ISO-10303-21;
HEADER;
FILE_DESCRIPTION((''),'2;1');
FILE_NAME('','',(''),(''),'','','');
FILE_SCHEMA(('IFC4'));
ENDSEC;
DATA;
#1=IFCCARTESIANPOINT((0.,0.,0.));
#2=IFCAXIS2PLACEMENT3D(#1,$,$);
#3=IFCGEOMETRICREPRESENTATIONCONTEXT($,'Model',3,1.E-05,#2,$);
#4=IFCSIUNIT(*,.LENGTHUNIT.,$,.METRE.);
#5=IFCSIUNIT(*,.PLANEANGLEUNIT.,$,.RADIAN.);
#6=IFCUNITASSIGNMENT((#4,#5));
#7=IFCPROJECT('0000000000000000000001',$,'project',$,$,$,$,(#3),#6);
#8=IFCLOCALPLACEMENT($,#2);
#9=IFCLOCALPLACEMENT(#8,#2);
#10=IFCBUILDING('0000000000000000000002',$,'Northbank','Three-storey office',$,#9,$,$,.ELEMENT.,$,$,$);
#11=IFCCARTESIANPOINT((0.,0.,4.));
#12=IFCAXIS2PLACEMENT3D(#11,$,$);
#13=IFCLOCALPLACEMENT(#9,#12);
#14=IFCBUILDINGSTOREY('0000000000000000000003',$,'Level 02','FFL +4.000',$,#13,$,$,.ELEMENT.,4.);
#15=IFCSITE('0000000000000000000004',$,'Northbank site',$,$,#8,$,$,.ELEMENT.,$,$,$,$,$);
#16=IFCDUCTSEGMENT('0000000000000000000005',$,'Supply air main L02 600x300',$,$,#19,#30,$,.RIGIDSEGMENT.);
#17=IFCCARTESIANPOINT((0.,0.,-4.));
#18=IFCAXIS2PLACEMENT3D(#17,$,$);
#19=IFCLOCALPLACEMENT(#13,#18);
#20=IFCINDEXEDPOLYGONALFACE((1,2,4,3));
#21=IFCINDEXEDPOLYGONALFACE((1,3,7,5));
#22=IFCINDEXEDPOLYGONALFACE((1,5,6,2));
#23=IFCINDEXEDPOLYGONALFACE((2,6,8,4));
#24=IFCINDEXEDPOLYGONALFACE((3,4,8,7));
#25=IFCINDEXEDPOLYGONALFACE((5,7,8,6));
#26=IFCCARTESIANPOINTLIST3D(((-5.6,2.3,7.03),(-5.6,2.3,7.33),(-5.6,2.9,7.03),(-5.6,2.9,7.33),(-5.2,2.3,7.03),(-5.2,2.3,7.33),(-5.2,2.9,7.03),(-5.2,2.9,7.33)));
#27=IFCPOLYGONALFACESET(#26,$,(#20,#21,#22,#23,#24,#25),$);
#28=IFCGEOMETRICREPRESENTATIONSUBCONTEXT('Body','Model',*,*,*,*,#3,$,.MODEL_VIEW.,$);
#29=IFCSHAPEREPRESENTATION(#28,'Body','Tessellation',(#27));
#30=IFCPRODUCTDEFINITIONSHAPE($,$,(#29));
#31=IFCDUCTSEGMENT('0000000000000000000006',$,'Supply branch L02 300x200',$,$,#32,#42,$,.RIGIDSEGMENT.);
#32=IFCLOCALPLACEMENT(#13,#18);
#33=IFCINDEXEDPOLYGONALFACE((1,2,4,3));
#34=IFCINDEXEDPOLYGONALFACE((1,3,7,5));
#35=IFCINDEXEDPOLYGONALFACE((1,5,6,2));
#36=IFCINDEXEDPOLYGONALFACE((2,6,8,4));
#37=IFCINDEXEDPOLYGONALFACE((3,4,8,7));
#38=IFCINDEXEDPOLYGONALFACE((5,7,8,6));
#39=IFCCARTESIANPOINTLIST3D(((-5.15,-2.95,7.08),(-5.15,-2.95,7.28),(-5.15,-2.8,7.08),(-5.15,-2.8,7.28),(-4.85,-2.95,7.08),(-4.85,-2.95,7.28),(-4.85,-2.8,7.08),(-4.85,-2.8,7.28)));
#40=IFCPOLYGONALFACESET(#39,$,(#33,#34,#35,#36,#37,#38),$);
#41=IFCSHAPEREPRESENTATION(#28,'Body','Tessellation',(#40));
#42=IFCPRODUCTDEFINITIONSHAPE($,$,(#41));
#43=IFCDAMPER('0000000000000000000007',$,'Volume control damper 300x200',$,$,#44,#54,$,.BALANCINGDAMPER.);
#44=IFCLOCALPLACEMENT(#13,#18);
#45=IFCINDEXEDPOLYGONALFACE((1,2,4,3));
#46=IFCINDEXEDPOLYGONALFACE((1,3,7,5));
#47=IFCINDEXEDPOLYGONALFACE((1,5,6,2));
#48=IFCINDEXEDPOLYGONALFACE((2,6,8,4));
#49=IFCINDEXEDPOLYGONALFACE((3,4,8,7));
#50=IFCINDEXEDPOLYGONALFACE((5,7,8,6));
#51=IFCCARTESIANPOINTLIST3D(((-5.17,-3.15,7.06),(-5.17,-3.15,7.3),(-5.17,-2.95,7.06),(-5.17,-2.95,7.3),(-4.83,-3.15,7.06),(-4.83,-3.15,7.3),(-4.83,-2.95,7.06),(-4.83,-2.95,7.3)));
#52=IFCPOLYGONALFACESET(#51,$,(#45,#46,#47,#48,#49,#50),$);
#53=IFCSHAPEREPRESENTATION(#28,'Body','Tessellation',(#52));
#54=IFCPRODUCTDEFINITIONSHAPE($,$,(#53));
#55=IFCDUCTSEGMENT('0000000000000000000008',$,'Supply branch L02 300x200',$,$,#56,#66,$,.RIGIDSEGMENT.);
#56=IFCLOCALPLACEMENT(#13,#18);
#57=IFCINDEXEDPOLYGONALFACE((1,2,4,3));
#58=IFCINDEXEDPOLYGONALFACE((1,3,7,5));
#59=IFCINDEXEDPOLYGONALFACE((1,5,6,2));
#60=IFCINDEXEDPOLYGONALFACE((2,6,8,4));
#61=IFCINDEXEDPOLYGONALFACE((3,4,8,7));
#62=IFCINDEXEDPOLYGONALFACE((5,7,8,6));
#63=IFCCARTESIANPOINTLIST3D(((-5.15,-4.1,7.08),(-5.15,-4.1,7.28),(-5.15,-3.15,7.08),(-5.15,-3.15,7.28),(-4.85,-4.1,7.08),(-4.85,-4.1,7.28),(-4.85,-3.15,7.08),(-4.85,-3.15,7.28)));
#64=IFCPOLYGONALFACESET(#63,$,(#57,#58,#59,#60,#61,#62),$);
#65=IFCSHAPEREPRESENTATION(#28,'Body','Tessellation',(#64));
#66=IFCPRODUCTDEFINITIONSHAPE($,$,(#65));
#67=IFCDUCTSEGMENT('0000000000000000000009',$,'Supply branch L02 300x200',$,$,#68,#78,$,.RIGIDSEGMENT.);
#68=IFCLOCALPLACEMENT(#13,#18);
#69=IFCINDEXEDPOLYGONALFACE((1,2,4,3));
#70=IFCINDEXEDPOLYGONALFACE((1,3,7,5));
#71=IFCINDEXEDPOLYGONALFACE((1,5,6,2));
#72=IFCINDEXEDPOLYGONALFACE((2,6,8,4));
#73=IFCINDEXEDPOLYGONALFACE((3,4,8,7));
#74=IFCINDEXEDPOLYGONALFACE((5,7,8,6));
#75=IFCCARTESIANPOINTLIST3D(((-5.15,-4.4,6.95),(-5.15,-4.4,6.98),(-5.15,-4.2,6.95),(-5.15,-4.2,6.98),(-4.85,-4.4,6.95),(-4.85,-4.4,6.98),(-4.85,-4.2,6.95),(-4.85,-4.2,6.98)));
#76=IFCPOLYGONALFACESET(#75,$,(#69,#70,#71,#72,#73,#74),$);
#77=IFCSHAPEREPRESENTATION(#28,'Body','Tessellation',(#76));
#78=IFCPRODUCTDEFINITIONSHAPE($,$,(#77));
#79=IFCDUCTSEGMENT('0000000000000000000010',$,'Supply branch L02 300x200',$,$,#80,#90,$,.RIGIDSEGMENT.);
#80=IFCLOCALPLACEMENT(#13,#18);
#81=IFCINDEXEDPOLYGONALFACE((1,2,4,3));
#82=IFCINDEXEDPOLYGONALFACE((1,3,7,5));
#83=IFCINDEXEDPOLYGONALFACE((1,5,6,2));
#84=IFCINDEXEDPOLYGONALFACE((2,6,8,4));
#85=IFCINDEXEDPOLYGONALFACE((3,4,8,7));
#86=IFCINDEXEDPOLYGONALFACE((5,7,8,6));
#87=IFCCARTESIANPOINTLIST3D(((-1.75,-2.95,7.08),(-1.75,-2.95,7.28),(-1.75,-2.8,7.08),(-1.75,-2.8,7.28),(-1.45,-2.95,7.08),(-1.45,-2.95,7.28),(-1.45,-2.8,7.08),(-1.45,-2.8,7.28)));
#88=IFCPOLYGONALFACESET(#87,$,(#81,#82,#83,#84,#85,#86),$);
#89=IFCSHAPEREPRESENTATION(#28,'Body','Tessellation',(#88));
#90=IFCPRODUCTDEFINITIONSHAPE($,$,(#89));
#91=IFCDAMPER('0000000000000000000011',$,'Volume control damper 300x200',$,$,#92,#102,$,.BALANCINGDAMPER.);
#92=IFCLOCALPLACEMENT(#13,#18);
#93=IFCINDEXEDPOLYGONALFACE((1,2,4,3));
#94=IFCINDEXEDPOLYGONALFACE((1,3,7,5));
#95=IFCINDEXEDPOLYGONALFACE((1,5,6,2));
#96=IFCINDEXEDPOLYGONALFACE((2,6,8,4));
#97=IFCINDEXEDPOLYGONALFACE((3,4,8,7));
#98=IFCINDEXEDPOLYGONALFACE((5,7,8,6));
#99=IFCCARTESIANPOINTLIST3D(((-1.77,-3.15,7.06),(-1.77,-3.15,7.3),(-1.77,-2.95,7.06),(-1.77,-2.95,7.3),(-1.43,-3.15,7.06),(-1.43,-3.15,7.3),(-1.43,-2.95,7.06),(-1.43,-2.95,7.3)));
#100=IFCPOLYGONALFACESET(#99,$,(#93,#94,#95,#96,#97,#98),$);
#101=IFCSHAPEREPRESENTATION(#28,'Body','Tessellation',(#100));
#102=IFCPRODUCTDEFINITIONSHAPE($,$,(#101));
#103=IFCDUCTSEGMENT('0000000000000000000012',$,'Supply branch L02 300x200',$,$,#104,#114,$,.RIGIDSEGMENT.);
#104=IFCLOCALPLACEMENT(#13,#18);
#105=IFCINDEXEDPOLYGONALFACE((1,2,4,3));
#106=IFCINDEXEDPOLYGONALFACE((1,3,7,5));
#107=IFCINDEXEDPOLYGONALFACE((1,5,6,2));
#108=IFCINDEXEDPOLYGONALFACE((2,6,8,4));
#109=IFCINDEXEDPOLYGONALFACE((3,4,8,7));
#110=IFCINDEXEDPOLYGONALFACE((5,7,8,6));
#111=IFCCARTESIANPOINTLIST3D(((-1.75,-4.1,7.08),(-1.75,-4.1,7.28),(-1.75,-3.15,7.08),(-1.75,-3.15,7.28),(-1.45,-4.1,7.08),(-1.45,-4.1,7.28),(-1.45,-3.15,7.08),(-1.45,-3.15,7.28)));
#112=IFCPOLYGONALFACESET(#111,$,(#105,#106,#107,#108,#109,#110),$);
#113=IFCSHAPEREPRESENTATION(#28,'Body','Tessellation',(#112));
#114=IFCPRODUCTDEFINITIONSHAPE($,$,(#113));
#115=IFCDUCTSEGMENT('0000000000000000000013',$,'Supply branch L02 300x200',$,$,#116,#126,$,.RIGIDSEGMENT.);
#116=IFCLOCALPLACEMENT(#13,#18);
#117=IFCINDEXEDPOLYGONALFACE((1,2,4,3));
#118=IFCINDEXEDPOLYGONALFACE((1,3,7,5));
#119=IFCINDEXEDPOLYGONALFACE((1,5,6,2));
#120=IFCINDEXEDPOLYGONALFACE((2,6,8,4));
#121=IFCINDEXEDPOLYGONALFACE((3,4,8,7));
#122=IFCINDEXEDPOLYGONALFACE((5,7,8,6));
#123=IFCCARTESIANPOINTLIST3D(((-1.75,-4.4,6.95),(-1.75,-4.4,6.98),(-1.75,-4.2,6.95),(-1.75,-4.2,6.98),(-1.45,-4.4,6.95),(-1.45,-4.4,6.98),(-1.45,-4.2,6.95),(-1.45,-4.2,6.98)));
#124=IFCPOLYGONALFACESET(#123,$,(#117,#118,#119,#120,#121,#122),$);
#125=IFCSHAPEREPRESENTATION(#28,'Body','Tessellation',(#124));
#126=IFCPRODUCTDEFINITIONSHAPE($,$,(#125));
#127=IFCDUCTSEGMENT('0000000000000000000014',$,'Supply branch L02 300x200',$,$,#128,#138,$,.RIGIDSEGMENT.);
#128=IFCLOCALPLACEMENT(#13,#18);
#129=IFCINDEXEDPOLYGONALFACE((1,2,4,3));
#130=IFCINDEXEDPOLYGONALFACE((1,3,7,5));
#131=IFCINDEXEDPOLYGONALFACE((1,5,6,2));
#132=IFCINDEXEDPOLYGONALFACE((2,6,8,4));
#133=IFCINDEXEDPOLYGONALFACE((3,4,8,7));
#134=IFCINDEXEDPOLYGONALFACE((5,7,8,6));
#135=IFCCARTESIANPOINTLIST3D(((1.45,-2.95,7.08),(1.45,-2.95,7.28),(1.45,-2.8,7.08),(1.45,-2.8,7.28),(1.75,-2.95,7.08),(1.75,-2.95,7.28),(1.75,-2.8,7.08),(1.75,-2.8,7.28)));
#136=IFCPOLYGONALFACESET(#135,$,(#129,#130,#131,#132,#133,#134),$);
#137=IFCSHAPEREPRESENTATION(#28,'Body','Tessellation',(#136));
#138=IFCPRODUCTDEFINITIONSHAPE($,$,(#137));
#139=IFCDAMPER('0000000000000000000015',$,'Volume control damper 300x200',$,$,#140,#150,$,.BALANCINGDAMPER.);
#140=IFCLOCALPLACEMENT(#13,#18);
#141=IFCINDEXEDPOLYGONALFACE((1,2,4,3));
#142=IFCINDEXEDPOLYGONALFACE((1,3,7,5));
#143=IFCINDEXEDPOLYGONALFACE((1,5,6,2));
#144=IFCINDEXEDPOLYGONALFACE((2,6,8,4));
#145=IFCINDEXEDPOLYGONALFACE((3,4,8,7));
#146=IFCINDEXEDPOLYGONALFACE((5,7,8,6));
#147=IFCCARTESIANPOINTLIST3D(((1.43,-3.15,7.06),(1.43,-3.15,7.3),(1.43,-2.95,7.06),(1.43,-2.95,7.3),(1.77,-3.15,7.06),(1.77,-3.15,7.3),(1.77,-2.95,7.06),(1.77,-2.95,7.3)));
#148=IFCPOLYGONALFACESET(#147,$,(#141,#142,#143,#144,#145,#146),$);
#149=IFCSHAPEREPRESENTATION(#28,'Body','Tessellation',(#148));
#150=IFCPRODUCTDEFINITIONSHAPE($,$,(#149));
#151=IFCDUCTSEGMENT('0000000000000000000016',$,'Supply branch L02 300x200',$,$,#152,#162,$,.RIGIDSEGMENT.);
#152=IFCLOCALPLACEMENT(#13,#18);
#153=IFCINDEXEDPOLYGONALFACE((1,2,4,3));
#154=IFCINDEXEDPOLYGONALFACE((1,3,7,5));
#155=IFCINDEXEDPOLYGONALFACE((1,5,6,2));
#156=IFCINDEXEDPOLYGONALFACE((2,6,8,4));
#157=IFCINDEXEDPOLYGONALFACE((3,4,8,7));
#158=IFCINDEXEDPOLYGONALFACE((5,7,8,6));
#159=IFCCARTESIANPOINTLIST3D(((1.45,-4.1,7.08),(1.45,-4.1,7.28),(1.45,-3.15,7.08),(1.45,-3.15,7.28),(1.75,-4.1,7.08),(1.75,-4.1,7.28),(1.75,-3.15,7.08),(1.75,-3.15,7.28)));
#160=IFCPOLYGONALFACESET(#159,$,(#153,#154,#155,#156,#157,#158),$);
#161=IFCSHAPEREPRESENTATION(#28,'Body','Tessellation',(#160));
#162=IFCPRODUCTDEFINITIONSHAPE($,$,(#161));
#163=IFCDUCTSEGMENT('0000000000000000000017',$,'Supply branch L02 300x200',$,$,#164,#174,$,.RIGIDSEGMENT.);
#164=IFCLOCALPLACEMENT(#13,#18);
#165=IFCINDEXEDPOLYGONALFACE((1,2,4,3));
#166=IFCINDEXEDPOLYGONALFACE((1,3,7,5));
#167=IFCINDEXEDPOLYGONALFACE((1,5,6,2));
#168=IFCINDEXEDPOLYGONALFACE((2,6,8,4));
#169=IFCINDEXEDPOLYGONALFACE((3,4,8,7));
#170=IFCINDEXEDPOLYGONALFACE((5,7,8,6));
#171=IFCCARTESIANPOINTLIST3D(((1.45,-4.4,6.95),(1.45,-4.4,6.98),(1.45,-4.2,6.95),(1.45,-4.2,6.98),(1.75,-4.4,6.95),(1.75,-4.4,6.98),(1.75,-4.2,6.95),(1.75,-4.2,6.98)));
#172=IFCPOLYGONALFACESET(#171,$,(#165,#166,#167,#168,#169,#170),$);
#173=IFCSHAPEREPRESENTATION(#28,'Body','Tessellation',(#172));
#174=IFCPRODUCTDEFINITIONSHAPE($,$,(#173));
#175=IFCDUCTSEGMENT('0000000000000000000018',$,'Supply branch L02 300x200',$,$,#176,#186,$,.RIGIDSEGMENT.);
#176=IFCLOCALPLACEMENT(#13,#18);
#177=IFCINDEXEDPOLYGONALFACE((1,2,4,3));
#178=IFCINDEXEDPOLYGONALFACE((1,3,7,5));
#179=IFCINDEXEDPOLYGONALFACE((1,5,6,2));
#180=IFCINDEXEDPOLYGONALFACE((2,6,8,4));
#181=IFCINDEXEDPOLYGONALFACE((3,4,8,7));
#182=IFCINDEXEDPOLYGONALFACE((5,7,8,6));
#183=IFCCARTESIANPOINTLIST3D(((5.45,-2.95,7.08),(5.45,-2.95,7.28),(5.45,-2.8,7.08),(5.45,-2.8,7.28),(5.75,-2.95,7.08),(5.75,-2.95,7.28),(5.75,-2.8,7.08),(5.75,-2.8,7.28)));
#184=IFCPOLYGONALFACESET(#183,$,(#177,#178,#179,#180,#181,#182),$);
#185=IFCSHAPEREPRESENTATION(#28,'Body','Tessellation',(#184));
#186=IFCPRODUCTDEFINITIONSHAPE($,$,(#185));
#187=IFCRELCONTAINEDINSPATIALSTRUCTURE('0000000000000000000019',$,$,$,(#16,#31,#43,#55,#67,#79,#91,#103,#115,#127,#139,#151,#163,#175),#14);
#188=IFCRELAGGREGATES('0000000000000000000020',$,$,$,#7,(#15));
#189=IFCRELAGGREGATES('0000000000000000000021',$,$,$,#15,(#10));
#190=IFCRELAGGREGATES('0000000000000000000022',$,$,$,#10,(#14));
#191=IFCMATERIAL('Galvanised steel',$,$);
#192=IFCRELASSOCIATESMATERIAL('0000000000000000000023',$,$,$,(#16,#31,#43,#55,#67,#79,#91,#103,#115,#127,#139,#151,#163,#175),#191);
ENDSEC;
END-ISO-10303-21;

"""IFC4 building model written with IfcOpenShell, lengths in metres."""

from ifc_helpers import new_model, si_unit, frame, origin, place, context, subcontext, project, spatial, rectangle, extrude, material, element, save


model = new_model("IFC4")

# Units and contexts
model_context = context("Model", 3, precision=1e-05, world=origin())
body_context = subcontext(model_context, "Body", "Model", "MODEL_VIEW")
ifc_project = project(units=[si_unit("LENGTHUNIT", "METRE"), si_unit("PLANEANGLEUNIT", "RADIAN")], contexts=[model_context])

# Site, building, storey
site_placement = place(None, origin())
site = spatial("IfcSite", under=ifc_project, at=site_placement, Name="Northbank site", CompositionType="ELEMENT")
building_placement = place(site_placement, origin())
building = spatial("IfcBuilding", under=site, at=building_placement, Name="Northbank", Description="Three-storey office", CompositionType="ELEMENT")
storey_placement = place(building_placement, frame((0.0, 0.0, 4.0)))
storey = spatial("IfcBuildingStorey", under=building, at=storey_placement, Name="Level 02", Description="FFL +4.000", CompositionType="ELEMENT", Elevation=4.0)

# Duct segment
ifc_material_1 = material(Name="Galvanised steel")
duct_segment_1_placement = place(storey_placement, frame((0.0, 0.0, -4.0)))
element("IfcDuctSegment", 1, at=duct_segment_1_placement, inside=storey, material=ifc_material_1, Name="Supply air main L02 600x300", PredefinedType="RIGIDSEGMENT", context=body_context, shape_type="SweptSolid", body=[
    extrude(rectangle(XDim=0.6, YDim=0.3), frame((-5.2, 2.6, 7.18), z_axis=(-1.0, 0.0, 0.0), x_axis=(0.0, -1.0, 0.0)), (0.0, 0.0, 1.0), 0.4),
])

# Duct segment
duct_segment_2_placement = place(storey_placement, frame((0.0, 0.0, -4.0)))
element("IfcDuctSegment", 2, at=duct_segment_2_placement, inside=storey, material=ifc_material_1, Name="Supply branch L02 300x200", PredefinedType="RIGIDSEGMENT", context=body_context, shape_type="SweptSolid", body=[
    extrude(rectangle(XDim=0.3, YDim=0.2), frame((-5.0, -2.8, 7.18), z_axis=(0.0, -1.0, 0.0), x_axis=(1.0, 0.0, 0.0)), (0.0, 0.0, 1.0), 0.15),
])

# Damper
damper_1_placement = place(storey_placement, frame((0.0, 0.0, -4.0)))
element("IfcDamper", 3, at=damper_1_placement, inside=storey, material=ifc_material_1, Name="Volume control damper 300x200", PredefinedType="BALANCINGDAMPER", context=body_context, shape_type="SweptSolid", body=[
    extrude(rectangle(XDim=0.34, YDim=0.24), frame((-5.0, -2.95, 7.18), z_axis=(0.0, -1.0, 0.0), x_axis=(1.0, 0.0, 0.0)), (0.0, 0.0, 1.0), 0.2),
])

# Duct segments
duct_segment_3_placement = place(storey_placement, frame((0.0, 0.0, -4.0)))
element("IfcDuctSegment", 4, at=duct_segment_3_placement, inside=storey, material=ifc_material_1, Name="Supply branch L02 300x200", PredefinedType="RIGIDSEGMENT", context=body_context, shape_type="SweptSolid", body=[
    extrude(rectangle(XDim=0.3, YDim=0.2), frame((-5.0, -3.15, 7.18), z_axis=(0.0, -1.0, 0.0), x_axis=(1.0, 0.0, 0.0)), (0.0, 0.0, 1.0), 0.95),
])
duct_segment_4_placement = place(storey_placement, frame((0.0, 0.0, -4.0)))
element("IfcDuctSegment", 5, at=duct_segment_4_placement, inside=storey, material=ifc_material_1, Name="Supply branch L02 300x200", PredefinedType="RIGIDSEGMENT", context=body_context, shape_type="SweptSolid", body=[
    extrude(rectangle(XDim=0.3, YDim=0.2), frame((-5.0, -4.3, 6.98), z_axis=(0.0, 0.0, -1.0), x_axis=(1.0, 0.0, 0.0)), (0.0, 0.0, 1.0), 0.03),
])

# Duct segment
duct_segment_5_placement = place(storey_placement, frame((0.0, 0.0, -4.0)))
element("IfcDuctSegment", 6, at=duct_segment_5_placement, inside=storey, material=ifc_material_1, Name="Supply branch L02 300x200", PredefinedType="RIGIDSEGMENT", context=body_context, shape_type="SweptSolid", body=[
    extrude(rectangle(XDim=0.3, YDim=0.2), frame((-1.6, -2.8, 7.18), z_axis=(0.0, -1.0, 0.0), x_axis=(1.0, 0.0, 0.0)), (0.0, 0.0, 1.0), 0.15),
])

# Damper
damper_2_placement = place(storey_placement, frame((0.0, 0.0, -4.0)))
element("IfcDamper", 7, at=damper_2_placement, inside=storey, material=ifc_material_1, Name="Volume control damper 300x200", PredefinedType="BALANCINGDAMPER", context=body_context, shape_type="SweptSolid", body=[
    extrude(rectangle(XDim=0.34, YDim=0.24), frame((-1.6, -2.95, 7.18), z_axis=(0.0, -1.0, 0.0), x_axis=(1.0, 0.0, 0.0)), (0.0, 0.0, 1.0), 0.2),
])

# Duct segments
duct_segment_6_placement = place(storey_placement, frame((0.0, 0.0, -4.0)))
element("IfcDuctSegment", 8, at=duct_segment_6_placement, inside=storey, material=ifc_material_1, Name="Supply branch L02 300x200", PredefinedType="RIGIDSEGMENT", context=body_context, shape_type="SweptSolid", body=[
    extrude(rectangle(XDim=0.3, YDim=0.2), frame((-1.6, -3.15, 7.18), z_axis=(0.0, -1.0, 0.0), x_axis=(1.0, 0.0, 0.0)), (0.0, 0.0, 1.0), 0.95),
])
duct_segment_7_placement = place(storey_placement, frame((0.0, 0.0, -4.0)))
element("IfcDuctSegment", 9, at=duct_segment_7_placement, inside=storey, material=ifc_material_1, Name="Supply branch L02 300x200", PredefinedType="RIGIDSEGMENT", context=body_context, shape_type="SweptSolid", body=[
    extrude(rectangle(XDim=0.3, YDim=0.2), frame((-1.6, -4.3, 6.98), z_axis=(0.0, 0.0, -1.0), x_axis=(1.0, 0.0, 0.0)), (0.0, 0.0, 1.0), 0.03),
])

# Duct segment
duct_segment_8_placement = place(storey_placement, frame((0.0, 0.0, -4.0)))
element("IfcDuctSegment", 10, at=duct_segment_8_placement, inside=storey, material=ifc_material_1, Name="Supply branch L02 300x200", PredefinedType="RIGIDSEGMENT", context=body_context, shape_type="SweptSolid", body=[
    extrude(rectangle(XDim=0.3, YDim=0.2), frame((1.6, -2.8, 7.18), z_axis=(0.0, -1.0, 0.0), x_axis=(1.0, 0.0, 0.0)), (0.0, 0.0, 1.0), 0.15),
])

# Damper
damper_3_placement = place(storey_placement, frame((0.0, 0.0, -4.0)))
element("IfcDamper", 11, at=damper_3_placement, inside=storey, material=ifc_material_1, Name="Volume control damper 300x200", PredefinedType="BALANCINGDAMPER", context=body_context, shape_type="SweptSolid", body=[
    extrude(rectangle(XDim=0.34, YDim=0.24), frame((1.6, -2.95, 7.18), z_axis=(0.0, -1.0, 0.0), x_axis=(1.0, 0.0, 0.0)), (0.0, 0.0, 1.0), 0.2),
])

# Duct segments
duct_segment_9_placement = place(storey_placement, frame((0.0, 0.0, -4.0)))
element("IfcDuctSegment", 12, at=duct_segment_9_placement, inside=storey, material=ifc_material_1, Name="Supply branch L02 300x200", PredefinedType="RIGIDSEGMENT", context=body_context, shape_type="SweptSolid", body=[
    extrude(rectangle(XDim=0.3, YDim=0.2), frame((1.6, -3.15, 7.18), z_axis=(0.0, -1.0, 0.0), x_axis=(1.0, 0.0, 0.0)), (0.0, 0.0, 1.0), 0.95),
])
duct_segment_10_placement = place(storey_placement, frame((0.0, 0.0, -4.0)))
element("IfcDuctSegment", 13, at=duct_segment_10_placement, inside=storey, material=ifc_material_1, Name="Supply branch L02 300x200", PredefinedType="RIGIDSEGMENT", context=body_context, shape_type="SweptSolid", body=[
    extrude(rectangle(XDim=0.3, YDim=0.2), frame((1.6, -4.3, 6.98), z_axis=(0.0, 0.0, -1.0), x_axis=(1.0, 0.0, 0.0)), (0.0, 0.0, 1.0), 0.03),
])

# Duct segment
duct_segment_11_placement = place(storey_placement, frame((0.0, 0.0, -4.0)))
element("IfcDuctSegment", 14, at=duct_segment_11_placement, inside=storey, material=ifc_material_1, Name="Supply branch L02 300x200", PredefinedType="RIGIDSEGMENT", context=body_context, shape_type="SweptSolid", body=[
    extrude(rectangle(XDim=0.3, YDim=0.2), frame((5.6, -2.8, 7.18), z_axis=(0.0, -1.0, 0.0), x_axis=(1.0, 0.0, 0.0)), (0.0, 0.0, 1.0), 0.15),
])

save(model, "model.ifc")
